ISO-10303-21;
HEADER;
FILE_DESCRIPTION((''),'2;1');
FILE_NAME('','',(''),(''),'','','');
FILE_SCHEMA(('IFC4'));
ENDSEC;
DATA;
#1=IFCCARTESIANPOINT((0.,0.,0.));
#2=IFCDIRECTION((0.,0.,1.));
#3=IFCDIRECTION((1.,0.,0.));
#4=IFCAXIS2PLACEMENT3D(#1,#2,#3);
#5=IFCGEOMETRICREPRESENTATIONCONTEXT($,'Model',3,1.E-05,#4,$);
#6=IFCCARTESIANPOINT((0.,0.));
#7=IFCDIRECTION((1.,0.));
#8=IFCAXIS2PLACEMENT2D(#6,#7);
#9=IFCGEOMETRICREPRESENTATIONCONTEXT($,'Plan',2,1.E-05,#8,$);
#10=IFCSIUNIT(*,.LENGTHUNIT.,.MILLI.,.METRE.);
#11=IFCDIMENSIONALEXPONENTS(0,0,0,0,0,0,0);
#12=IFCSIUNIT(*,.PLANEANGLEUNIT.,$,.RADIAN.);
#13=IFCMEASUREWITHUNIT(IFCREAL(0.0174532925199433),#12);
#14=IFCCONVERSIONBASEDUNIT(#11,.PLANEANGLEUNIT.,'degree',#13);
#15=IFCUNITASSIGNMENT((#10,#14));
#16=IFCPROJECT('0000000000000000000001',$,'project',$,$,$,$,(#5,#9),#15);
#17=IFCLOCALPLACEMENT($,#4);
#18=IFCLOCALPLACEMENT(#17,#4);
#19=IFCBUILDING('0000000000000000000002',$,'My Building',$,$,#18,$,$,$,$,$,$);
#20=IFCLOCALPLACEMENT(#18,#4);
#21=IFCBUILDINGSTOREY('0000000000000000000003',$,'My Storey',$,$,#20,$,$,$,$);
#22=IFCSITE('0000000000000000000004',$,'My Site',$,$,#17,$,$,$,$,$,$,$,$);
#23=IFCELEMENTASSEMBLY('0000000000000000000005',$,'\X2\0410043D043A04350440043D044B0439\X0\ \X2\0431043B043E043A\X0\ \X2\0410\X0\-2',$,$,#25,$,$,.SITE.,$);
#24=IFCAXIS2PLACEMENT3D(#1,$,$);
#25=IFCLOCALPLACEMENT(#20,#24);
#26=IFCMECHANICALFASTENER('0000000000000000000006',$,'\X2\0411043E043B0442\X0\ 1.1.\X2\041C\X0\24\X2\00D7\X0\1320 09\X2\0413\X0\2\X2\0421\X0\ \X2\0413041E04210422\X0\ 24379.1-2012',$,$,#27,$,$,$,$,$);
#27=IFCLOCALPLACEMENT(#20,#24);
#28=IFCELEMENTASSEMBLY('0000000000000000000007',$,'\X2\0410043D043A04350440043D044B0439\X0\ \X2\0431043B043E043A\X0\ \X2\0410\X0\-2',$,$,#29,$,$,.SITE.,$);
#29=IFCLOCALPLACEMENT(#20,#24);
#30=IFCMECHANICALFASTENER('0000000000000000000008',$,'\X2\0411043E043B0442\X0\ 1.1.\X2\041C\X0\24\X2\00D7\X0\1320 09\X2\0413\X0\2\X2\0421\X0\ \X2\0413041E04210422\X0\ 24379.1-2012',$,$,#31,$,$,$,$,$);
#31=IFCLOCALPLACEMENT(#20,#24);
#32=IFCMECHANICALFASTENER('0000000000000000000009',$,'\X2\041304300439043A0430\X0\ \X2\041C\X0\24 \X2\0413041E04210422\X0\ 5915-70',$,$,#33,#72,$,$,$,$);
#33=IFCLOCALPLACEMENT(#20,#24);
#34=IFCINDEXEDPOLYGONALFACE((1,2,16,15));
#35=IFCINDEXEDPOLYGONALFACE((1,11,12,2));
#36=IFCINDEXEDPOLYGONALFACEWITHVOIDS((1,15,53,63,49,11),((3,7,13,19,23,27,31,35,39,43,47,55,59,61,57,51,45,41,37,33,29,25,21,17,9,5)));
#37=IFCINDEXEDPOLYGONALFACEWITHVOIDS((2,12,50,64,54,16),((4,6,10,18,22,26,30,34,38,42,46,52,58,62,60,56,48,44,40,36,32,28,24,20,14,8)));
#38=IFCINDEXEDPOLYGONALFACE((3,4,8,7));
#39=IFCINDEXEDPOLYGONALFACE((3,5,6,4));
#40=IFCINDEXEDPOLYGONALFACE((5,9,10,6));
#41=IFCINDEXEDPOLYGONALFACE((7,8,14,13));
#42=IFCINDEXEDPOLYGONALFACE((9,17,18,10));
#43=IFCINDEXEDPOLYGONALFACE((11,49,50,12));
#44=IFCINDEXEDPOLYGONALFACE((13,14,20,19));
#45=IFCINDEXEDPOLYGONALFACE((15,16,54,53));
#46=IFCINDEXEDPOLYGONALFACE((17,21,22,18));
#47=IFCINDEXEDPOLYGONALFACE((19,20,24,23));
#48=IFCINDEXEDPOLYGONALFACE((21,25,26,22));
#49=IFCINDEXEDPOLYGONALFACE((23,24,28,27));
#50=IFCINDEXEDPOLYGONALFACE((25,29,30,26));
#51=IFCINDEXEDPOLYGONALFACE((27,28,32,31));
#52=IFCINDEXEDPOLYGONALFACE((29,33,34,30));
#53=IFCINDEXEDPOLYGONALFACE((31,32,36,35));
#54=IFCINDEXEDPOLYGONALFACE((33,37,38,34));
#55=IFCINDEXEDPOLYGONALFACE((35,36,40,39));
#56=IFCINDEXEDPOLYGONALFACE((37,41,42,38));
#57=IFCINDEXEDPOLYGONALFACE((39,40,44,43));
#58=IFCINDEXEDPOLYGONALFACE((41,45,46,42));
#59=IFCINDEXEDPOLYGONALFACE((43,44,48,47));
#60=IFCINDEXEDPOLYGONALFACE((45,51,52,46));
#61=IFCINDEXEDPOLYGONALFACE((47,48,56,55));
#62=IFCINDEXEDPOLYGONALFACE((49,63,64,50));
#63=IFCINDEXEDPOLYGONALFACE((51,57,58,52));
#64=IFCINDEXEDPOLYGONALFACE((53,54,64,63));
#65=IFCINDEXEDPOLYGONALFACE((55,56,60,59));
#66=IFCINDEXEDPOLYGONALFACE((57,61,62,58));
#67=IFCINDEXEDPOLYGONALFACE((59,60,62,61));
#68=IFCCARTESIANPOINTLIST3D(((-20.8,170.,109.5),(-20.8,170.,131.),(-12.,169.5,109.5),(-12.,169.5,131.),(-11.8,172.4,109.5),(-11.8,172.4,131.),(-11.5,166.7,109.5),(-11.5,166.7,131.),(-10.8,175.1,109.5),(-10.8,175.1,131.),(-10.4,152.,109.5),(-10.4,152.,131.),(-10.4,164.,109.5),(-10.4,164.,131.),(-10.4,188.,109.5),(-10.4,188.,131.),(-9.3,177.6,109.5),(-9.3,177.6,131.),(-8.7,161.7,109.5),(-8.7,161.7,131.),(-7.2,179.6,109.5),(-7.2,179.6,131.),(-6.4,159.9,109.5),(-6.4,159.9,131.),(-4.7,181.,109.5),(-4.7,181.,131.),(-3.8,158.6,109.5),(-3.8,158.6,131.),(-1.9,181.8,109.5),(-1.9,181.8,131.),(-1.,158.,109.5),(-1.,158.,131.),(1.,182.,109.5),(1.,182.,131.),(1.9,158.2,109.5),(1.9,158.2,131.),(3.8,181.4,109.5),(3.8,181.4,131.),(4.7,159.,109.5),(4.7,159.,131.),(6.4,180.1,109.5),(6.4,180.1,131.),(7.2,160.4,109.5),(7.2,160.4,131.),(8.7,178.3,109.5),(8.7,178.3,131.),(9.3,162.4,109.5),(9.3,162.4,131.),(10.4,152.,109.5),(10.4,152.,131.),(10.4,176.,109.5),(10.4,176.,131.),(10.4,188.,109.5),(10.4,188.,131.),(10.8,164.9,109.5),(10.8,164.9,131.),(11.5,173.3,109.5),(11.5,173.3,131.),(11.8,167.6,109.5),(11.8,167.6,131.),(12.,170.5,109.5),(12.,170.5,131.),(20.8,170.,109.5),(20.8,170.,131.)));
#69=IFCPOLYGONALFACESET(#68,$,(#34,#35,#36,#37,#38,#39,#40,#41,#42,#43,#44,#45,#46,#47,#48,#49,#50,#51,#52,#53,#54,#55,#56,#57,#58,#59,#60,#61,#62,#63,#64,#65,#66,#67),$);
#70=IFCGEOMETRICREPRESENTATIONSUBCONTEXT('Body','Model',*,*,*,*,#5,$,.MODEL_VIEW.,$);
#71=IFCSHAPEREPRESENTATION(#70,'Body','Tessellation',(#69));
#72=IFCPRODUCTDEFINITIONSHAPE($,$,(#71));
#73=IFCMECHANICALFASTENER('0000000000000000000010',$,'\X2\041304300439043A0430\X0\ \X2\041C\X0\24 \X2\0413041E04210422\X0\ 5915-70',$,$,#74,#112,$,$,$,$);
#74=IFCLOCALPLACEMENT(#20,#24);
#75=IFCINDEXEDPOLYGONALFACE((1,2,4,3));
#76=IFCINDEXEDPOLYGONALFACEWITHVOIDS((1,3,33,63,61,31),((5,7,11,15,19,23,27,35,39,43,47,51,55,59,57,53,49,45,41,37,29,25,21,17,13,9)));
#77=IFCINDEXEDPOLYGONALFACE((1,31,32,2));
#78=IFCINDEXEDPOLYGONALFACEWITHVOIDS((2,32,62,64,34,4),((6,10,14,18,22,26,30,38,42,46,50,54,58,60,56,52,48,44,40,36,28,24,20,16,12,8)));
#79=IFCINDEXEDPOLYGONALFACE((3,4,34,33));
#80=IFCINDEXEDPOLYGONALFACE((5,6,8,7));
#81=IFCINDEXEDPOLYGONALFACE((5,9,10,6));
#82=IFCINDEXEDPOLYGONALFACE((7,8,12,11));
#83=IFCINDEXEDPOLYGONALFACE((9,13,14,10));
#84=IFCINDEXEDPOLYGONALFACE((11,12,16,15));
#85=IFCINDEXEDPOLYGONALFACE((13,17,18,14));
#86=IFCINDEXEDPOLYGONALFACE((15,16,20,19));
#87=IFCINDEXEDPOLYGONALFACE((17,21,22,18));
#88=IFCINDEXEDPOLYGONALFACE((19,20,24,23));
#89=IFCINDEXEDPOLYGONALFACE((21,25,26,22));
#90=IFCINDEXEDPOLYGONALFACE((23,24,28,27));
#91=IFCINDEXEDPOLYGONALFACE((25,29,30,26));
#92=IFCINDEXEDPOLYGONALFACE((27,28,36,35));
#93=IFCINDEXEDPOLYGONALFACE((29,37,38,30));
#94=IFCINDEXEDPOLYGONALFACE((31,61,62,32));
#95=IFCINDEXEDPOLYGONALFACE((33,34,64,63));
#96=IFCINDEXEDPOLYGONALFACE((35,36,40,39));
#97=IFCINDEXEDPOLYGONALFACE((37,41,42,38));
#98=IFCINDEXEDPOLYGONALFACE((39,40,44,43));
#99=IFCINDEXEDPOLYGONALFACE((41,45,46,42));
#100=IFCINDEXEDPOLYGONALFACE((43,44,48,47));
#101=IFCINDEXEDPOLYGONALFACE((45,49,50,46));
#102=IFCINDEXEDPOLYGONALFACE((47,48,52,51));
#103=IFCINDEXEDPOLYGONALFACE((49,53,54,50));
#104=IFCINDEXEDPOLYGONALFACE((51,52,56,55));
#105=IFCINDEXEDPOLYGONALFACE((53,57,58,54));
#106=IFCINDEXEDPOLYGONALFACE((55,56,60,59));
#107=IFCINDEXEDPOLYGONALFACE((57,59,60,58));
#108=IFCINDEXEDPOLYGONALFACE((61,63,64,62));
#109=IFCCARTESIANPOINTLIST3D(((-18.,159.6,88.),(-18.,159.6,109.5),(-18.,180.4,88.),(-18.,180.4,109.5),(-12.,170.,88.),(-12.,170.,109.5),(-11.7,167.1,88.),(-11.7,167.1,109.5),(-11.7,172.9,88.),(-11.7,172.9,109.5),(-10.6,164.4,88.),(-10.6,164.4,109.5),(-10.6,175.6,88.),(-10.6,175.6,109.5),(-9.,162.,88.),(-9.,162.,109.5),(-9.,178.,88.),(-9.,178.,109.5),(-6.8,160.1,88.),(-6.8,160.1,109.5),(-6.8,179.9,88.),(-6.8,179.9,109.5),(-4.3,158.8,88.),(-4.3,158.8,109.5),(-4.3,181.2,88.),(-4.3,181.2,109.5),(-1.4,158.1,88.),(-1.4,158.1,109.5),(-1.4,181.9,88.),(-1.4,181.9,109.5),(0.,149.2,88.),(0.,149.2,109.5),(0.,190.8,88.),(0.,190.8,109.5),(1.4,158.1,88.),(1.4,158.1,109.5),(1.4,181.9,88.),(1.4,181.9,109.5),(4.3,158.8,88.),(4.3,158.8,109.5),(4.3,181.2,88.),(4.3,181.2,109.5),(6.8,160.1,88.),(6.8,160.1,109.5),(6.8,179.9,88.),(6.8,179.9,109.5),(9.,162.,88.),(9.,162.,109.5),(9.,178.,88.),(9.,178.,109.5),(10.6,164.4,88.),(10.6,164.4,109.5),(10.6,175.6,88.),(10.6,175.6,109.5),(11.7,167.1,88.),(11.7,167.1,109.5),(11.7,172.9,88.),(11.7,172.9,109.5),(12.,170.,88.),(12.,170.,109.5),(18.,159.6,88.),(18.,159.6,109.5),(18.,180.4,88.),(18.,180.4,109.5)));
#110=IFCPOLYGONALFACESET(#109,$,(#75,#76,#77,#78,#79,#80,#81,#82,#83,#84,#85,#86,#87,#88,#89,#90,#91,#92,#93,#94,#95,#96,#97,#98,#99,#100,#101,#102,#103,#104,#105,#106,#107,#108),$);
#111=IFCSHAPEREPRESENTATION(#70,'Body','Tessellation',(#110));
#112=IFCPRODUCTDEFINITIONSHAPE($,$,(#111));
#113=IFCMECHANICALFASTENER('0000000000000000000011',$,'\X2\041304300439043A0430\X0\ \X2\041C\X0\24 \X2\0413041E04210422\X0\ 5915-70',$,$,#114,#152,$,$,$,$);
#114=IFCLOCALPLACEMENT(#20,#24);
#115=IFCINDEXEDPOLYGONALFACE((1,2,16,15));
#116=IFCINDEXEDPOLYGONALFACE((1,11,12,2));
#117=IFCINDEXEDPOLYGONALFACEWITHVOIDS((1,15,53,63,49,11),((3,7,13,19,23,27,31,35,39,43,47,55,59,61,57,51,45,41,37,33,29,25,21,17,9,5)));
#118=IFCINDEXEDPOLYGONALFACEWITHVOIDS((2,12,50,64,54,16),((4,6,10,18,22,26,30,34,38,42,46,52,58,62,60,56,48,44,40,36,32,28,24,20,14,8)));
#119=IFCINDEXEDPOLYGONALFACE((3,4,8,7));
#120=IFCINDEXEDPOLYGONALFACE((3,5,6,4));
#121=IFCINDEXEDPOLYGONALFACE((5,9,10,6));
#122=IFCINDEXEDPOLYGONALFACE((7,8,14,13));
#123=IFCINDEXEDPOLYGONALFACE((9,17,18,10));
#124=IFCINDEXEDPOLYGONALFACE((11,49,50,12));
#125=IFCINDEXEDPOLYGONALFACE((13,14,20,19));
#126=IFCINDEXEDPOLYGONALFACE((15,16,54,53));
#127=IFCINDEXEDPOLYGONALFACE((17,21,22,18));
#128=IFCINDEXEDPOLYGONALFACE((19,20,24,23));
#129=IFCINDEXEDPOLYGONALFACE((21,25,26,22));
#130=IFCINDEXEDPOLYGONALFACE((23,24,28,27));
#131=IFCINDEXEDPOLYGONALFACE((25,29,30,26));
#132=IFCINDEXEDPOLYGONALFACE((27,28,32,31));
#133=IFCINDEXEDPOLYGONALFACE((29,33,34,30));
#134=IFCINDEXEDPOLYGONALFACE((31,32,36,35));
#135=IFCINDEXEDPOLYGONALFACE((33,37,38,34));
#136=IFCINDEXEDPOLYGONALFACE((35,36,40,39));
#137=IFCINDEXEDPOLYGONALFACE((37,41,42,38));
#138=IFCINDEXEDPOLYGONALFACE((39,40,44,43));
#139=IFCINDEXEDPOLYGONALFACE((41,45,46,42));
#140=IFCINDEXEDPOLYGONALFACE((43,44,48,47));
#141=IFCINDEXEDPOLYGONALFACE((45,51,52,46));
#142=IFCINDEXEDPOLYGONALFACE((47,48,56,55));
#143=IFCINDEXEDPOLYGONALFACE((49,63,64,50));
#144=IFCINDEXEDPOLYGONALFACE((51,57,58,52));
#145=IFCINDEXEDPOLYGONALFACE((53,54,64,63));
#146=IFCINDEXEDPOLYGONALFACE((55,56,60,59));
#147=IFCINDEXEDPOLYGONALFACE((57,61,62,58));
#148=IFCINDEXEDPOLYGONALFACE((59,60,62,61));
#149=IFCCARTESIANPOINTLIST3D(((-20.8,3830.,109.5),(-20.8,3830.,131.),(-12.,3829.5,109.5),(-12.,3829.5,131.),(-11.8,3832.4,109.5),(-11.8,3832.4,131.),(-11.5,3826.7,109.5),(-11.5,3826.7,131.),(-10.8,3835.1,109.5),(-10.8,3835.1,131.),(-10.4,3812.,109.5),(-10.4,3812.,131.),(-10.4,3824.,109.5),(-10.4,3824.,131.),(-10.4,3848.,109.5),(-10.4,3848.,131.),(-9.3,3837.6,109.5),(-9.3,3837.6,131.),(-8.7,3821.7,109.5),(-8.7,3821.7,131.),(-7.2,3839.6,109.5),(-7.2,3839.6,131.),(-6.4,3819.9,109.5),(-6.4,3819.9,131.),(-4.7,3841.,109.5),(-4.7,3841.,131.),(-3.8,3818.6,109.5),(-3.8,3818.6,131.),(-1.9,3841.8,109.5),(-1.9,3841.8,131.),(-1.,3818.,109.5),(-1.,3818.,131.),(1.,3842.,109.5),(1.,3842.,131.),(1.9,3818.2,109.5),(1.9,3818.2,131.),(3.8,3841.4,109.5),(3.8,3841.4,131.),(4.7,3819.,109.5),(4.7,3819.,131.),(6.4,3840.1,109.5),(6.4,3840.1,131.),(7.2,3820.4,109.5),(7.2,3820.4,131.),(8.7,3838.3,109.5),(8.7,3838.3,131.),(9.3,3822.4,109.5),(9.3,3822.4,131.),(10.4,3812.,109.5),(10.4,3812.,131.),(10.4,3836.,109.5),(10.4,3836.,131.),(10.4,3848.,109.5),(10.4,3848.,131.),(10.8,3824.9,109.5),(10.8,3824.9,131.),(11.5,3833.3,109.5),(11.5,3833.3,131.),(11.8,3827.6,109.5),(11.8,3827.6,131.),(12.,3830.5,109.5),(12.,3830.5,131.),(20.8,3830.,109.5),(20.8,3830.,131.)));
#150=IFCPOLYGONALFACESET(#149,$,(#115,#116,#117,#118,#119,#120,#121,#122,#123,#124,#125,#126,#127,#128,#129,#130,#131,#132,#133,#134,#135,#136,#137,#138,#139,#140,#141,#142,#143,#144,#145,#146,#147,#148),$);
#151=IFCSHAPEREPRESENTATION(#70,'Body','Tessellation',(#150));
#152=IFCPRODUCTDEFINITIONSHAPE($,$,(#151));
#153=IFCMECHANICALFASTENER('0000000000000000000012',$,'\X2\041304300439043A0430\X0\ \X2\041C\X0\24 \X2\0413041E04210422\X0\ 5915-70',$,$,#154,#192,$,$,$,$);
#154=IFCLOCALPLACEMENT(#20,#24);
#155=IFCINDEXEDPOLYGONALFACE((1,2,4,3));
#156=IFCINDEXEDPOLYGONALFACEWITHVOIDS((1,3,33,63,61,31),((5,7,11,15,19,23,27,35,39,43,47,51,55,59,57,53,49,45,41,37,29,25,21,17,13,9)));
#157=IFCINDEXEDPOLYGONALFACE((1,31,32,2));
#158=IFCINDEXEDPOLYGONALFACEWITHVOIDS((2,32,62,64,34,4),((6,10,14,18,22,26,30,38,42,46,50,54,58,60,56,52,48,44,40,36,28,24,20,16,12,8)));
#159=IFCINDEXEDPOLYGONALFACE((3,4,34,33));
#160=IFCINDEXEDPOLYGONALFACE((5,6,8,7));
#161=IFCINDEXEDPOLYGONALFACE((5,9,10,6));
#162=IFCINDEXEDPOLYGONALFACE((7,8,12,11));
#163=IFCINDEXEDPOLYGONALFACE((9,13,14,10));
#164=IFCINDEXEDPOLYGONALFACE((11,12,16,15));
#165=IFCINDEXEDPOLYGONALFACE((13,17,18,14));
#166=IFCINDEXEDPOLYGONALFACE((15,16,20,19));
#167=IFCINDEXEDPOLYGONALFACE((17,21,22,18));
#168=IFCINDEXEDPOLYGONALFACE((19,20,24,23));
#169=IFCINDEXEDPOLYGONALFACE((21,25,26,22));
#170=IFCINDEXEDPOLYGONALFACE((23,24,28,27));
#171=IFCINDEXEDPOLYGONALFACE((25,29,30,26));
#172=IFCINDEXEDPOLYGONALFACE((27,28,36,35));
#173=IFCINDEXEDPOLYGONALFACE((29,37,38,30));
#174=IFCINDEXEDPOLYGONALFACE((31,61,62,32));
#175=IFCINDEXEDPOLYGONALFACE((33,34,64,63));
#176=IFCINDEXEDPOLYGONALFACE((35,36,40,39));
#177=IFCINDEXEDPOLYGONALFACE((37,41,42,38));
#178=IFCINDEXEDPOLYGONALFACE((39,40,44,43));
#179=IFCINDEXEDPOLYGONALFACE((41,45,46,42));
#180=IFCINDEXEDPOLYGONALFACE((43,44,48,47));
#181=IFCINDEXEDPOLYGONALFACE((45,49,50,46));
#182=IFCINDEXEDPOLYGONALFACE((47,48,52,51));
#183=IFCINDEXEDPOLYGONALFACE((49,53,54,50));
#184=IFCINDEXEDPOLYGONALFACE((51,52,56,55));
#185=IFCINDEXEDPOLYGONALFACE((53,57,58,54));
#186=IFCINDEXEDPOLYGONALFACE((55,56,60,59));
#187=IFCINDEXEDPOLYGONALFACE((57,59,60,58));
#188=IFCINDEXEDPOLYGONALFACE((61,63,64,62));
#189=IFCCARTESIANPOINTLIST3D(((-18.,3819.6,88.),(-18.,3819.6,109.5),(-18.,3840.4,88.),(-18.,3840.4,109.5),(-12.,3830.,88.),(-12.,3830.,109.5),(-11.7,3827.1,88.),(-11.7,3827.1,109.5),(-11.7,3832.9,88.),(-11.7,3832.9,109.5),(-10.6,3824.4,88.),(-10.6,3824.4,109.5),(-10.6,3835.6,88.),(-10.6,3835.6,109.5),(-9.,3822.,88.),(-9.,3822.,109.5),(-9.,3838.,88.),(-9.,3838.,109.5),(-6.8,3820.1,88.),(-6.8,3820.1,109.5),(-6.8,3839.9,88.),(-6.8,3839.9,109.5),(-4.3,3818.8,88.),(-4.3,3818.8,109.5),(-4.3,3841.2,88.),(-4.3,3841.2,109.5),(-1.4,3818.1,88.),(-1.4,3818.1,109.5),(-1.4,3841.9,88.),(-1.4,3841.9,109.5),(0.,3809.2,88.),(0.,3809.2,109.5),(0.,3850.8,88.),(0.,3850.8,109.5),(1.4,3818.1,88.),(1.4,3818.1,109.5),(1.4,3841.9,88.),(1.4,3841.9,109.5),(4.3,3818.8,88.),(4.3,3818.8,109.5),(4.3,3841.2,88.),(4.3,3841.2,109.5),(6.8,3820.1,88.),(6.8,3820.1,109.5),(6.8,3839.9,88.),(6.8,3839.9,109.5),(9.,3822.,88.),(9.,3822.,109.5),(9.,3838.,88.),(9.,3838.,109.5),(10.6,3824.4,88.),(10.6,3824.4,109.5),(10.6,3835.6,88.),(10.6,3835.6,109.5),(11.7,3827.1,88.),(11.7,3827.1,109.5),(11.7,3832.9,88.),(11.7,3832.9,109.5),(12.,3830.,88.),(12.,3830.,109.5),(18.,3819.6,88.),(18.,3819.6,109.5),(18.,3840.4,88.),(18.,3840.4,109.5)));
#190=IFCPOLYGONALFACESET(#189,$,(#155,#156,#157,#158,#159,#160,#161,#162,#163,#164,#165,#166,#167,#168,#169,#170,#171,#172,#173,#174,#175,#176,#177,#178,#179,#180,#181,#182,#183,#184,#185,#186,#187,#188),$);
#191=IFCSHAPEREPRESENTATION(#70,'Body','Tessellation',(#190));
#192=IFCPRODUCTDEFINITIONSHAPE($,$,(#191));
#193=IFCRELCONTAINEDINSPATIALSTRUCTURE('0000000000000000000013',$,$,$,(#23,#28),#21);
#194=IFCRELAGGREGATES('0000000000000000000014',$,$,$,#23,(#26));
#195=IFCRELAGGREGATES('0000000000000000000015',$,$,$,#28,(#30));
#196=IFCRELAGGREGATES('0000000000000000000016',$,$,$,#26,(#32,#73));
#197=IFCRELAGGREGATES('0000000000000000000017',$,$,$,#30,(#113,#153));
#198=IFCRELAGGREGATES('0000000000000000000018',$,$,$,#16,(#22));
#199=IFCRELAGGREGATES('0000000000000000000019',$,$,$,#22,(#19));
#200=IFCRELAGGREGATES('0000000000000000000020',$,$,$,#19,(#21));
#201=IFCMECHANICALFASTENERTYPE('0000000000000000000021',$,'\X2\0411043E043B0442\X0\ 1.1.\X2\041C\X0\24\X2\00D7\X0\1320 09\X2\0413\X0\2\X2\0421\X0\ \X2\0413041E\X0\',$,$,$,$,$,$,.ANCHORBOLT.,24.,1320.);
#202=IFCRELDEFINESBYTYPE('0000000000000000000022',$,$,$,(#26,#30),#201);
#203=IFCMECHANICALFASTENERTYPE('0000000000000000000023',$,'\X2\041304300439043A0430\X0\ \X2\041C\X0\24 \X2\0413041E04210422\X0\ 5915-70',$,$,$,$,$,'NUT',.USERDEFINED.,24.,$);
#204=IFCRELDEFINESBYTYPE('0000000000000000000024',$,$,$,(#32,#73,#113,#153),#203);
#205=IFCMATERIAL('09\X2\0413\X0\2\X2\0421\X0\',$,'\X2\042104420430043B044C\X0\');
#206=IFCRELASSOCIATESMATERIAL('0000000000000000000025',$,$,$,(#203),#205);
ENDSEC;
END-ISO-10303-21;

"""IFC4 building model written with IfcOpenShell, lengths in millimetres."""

from ifc_helpers import new_model, entity, si_unit, converted_unit, frame, origin_with_axes, origin_2d_with_axis, place, context, subcontext, project, spatial, polyline, outline, extrude, source, transform, mapped, material, type_object, type_shapes, element, aggregate, save


model = new_model("IFC4")

# Units and contexts
model_context = context("Model", 3, precision=1e-05, world=origin_with_axes())
plan_context = context("Plan", 2, precision=1e-05, world=origin_2d_with_axis())
body_context = subcontext(model_context, "Body", "Model", "MODEL_VIEW")
ifc_project = project(units=[si_unit("LENGTHUNIT", "METRE", prefix="MILLI"), converted_unit("PLANEANGLEUNIT", "degree", entity("IfcReal", 0.0174532925199433), si_unit("PLANEANGLEUNIT", "RADIAN"), dimensions=[0, 0, 0, 0, 0, 0, 0])], contexts=[model_context, plan_context])

# Site, building, storey
site_placement = place(None, origin_with_axes())
site = spatial("IfcSite", under=ifc_project, at=site_placement, Name="My Site")
building_placement = place(site_placement, origin_with_axes())
building = spatial("IfcBuilding", under=site, at=building_placement, Name="My Building")
storey_placement = place(building_placement, origin_with_axes())
storey = spatial("IfcBuildingStorey", under=building, at=storey_placement, Name="My Storey")

# Shared definitions
placement = place(storey_placement, origin_with_axes())

# Element assemblies, mechanical fasteners
assembly_1 = element("IfcElementAssembly", 1, at=placement, inside=storey, Name="Анкерный блок А-2", AssemblyPlace="SITE")
ifc_material_1 = material(Name="09Г2С", Category="Сталь")
mechanical_fastener_type_1 = type_object("IfcMechanicalFastenerType", Name="Болт 1.1.М24×1320 09Г2С ГО", NominalDiameter=24.0, NominalLength=1320.0, PredefinedType="ANCHORBOLT")
mechanical_fastener_1_placement = place(placement, frame((0.0, 170.0, 0.0), z_axis=(0.0, 0.0, 1.0), x_axis=(-1.0, 0.0, 0.0)))
mechanical_fastener_1 = element("IfcMechanicalFastener", 2, at=mechanical_fastener_1_placement, type_object=mechanical_fastener_type_1, Name="Болт 1.1.М24×1320 09Г2С ГОСТ 24379.1-2012")
aggregate(assembly_1, [mechanical_fastener_1])
assembly_2_placement = place(storey_placement, frame((0.0, 4000.0, 0.0), z_axis=(0.0, 0.0, 1.0), x_axis=(1.0, 0.0, 0.0)))
assembly_2 = element("IfcElementAssembly", 3, at=assembly_2_placement, inside=storey, Name="Анкерный блок А-2", AssemblyPlace="SITE")
mechanical_fastener_2_placement = place(assembly_2_placement, frame((0.0, -170.0, 0.0), z_axis=(0.0, 0.0, 1.0), x_axis=(1.0, 0.0, 0.0)))
mechanical_fastener_2 = element("IfcMechanicalFastener", 4, at=mechanical_fastener_2_placement, type_object=mechanical_fastener_type_1, Name="Болт 1.1.М24×1320 09Г2С ГОСТ 24379.1-2012")
aggregate(assembly_2, [mechanical_fastener_2])

# Mechanical fasteners
mechanical_fastener_type_2 = type_object("IfcMechanicalFastenerType", Name="Гайка М24 ГОСТ 5915-70", ElementType="NUT", NominalDiameter=24.0, PredefinedType="USERDEFINED", material=ifc_material_1)
shared_shape_1 = source(origin_with_axes(), body_context, "Body", "SweptSolid", [
    extrude(outline(polyline([(-10.4, -18.0), (10.4, -18.0), (20.8, 0.0), (10.4, 18.0), (-10.4, 18.0), (-20.8, 0.0), (-10.4, -18.0)]), holes=[polyline([(-8.0, 9.0), (-5.6, 10.6), (-2.9, 11.7), (0.0, 12.0), (2.9, 11.7), (5.6, 10.6), (8.0, 9.0), (9.9, 6.8), (11.2, 4.3), (11.9, 1.4), (11.9, -1.4), (11.2, -4.3), (9.9, -6.8), (8.0, -9.0), (5.6, -10.6), (2.9, -11.7), (0.0, -12.0), (-2.9, -11.7), (-5.6, -10.6), (-8.0, -9.0), (-9.9, -6.8), (-11.2, -4.3), (-11.9, -1.4), (-11.9, 1.4), (-11.2, 4.3), (-9.9, 6.8), (-8.0, 9.0)])]), frame((0.0, 0.0, 0.0), z_axis=(0.0, 0.0, 1.0), x_axis=(0.0, 1.0, 0.0)), (0.0, 0.0, 1.0), 21.5),
])
type_shapes(mechanical_fastener_type_2, [shared_shape_1])
mechanical_fastener_3_placement = place(mechanical_fastener_1_placement, frame((0.0, 0.0, 109.5), z_axis=(0.0, 0.0, 1.0), x_axis=(0.866025, 0.5, 0.0)))
mechanical_fastener_3 = element("IfcMechanicalFastener", 5, at=mechanical_fastener_3_placement, type_object=mechanical_fastener_type_2, Name="Гайка М24 ГОСТ 5915-70", context=body_context, shape_type="MappedRepresentation", body=[
    mapped(shared_shape_1, transform((0.0, 0.0, 0.0), x_axis=(1.0, 0.0, 0.0), y_axis=(0.0, 1.0, 0.0), z_axis=(0.0, 0.0, 1.0), scale=1.0)),
])
mechanical_fastener_4_placement = place(mechanical_fastener_1_placement, frame((0.0, 0.0, 88.0), z_axis=(0.0, 0.0, 1.0), x_axis=(1.0, 0.0, 0.0)))
mechanical_fastener_4 = element("IfcMechanicalFastener", 6, at=mechanical_fastener_4_placement, type_object=mechanical_fastener_type_2, Name="Гайка М24 ГОСТ 5915-70", context=body_context, shape_type="MappedRepresentation", body=[
    mapped(shared_shape_1, transform((0.0, 0.0, 0.0), x_axis=(1.0, 0.0, 0.0), y_axis=(0.0, 1.0, 0.0), z_axis=(0.0, 0.0, 1.0), scale=1.0)),
])
mechanical_fastener_5_placement = place(mechanical_fastener_2_placement, frame((0.0, 0.0, 109.5), z_axis=(0.0, 0.0, 1.0), x_axis=(0.866025, 0.5, 0.0)))
mechanical_fastener_5 = element("IfcMechanicalFastener", 7, at=mechanical_fastener_5_placement, type_object=mechanical_fastener_type_2, Name="Гайка М24 ГОСТ 5915-70", context=body_context, shape_type="MappedRepresentation", body=[
    mapped(shared_shape_1, transform((0.0, 0.0, 0.0), x_axis=(1.0, 0.0, 0.0), y_axis=(0.0, 1.0, 0.0), z_axis=(0.0, 0.0, 1.0), scale=1.0)),
])
mechanical_fastener_6_placement = place(mechanical_fastener_2_placement, frame((0.0, 0.0, 88.0), z_axis=(0.0, 0.0, 1.0), x_axis=(1.0, 0.0, 0.0)))
mechanical_fastener_6 = element("IfcMechanicalFastener", 8, at=mechanical_fastener_6_placement, type_object=mechanical_fastener_type_2, Name="Гайка М24 ГОСТ 5915-70", context=body_context, shape_type="MappedRepresentation", body=[
    mapped(shared_shape_1, transform((0.0, 0.0, 0.0), x_axis=(1.0, 0.0, 0.0), y_axis=(0.0, 1.0, 0.0), z_axis=(0.0, 0.0, 1.0), scale=1.0)),
])
aggregate(mechanical_fastener_1, [mechanical_fastener_3, mechanical_fastener_4])
aggregate(mechanical_fastener_2, [mechanical_fastener_5, mechanical_fastener_6])

save(model, "model.ifc")
